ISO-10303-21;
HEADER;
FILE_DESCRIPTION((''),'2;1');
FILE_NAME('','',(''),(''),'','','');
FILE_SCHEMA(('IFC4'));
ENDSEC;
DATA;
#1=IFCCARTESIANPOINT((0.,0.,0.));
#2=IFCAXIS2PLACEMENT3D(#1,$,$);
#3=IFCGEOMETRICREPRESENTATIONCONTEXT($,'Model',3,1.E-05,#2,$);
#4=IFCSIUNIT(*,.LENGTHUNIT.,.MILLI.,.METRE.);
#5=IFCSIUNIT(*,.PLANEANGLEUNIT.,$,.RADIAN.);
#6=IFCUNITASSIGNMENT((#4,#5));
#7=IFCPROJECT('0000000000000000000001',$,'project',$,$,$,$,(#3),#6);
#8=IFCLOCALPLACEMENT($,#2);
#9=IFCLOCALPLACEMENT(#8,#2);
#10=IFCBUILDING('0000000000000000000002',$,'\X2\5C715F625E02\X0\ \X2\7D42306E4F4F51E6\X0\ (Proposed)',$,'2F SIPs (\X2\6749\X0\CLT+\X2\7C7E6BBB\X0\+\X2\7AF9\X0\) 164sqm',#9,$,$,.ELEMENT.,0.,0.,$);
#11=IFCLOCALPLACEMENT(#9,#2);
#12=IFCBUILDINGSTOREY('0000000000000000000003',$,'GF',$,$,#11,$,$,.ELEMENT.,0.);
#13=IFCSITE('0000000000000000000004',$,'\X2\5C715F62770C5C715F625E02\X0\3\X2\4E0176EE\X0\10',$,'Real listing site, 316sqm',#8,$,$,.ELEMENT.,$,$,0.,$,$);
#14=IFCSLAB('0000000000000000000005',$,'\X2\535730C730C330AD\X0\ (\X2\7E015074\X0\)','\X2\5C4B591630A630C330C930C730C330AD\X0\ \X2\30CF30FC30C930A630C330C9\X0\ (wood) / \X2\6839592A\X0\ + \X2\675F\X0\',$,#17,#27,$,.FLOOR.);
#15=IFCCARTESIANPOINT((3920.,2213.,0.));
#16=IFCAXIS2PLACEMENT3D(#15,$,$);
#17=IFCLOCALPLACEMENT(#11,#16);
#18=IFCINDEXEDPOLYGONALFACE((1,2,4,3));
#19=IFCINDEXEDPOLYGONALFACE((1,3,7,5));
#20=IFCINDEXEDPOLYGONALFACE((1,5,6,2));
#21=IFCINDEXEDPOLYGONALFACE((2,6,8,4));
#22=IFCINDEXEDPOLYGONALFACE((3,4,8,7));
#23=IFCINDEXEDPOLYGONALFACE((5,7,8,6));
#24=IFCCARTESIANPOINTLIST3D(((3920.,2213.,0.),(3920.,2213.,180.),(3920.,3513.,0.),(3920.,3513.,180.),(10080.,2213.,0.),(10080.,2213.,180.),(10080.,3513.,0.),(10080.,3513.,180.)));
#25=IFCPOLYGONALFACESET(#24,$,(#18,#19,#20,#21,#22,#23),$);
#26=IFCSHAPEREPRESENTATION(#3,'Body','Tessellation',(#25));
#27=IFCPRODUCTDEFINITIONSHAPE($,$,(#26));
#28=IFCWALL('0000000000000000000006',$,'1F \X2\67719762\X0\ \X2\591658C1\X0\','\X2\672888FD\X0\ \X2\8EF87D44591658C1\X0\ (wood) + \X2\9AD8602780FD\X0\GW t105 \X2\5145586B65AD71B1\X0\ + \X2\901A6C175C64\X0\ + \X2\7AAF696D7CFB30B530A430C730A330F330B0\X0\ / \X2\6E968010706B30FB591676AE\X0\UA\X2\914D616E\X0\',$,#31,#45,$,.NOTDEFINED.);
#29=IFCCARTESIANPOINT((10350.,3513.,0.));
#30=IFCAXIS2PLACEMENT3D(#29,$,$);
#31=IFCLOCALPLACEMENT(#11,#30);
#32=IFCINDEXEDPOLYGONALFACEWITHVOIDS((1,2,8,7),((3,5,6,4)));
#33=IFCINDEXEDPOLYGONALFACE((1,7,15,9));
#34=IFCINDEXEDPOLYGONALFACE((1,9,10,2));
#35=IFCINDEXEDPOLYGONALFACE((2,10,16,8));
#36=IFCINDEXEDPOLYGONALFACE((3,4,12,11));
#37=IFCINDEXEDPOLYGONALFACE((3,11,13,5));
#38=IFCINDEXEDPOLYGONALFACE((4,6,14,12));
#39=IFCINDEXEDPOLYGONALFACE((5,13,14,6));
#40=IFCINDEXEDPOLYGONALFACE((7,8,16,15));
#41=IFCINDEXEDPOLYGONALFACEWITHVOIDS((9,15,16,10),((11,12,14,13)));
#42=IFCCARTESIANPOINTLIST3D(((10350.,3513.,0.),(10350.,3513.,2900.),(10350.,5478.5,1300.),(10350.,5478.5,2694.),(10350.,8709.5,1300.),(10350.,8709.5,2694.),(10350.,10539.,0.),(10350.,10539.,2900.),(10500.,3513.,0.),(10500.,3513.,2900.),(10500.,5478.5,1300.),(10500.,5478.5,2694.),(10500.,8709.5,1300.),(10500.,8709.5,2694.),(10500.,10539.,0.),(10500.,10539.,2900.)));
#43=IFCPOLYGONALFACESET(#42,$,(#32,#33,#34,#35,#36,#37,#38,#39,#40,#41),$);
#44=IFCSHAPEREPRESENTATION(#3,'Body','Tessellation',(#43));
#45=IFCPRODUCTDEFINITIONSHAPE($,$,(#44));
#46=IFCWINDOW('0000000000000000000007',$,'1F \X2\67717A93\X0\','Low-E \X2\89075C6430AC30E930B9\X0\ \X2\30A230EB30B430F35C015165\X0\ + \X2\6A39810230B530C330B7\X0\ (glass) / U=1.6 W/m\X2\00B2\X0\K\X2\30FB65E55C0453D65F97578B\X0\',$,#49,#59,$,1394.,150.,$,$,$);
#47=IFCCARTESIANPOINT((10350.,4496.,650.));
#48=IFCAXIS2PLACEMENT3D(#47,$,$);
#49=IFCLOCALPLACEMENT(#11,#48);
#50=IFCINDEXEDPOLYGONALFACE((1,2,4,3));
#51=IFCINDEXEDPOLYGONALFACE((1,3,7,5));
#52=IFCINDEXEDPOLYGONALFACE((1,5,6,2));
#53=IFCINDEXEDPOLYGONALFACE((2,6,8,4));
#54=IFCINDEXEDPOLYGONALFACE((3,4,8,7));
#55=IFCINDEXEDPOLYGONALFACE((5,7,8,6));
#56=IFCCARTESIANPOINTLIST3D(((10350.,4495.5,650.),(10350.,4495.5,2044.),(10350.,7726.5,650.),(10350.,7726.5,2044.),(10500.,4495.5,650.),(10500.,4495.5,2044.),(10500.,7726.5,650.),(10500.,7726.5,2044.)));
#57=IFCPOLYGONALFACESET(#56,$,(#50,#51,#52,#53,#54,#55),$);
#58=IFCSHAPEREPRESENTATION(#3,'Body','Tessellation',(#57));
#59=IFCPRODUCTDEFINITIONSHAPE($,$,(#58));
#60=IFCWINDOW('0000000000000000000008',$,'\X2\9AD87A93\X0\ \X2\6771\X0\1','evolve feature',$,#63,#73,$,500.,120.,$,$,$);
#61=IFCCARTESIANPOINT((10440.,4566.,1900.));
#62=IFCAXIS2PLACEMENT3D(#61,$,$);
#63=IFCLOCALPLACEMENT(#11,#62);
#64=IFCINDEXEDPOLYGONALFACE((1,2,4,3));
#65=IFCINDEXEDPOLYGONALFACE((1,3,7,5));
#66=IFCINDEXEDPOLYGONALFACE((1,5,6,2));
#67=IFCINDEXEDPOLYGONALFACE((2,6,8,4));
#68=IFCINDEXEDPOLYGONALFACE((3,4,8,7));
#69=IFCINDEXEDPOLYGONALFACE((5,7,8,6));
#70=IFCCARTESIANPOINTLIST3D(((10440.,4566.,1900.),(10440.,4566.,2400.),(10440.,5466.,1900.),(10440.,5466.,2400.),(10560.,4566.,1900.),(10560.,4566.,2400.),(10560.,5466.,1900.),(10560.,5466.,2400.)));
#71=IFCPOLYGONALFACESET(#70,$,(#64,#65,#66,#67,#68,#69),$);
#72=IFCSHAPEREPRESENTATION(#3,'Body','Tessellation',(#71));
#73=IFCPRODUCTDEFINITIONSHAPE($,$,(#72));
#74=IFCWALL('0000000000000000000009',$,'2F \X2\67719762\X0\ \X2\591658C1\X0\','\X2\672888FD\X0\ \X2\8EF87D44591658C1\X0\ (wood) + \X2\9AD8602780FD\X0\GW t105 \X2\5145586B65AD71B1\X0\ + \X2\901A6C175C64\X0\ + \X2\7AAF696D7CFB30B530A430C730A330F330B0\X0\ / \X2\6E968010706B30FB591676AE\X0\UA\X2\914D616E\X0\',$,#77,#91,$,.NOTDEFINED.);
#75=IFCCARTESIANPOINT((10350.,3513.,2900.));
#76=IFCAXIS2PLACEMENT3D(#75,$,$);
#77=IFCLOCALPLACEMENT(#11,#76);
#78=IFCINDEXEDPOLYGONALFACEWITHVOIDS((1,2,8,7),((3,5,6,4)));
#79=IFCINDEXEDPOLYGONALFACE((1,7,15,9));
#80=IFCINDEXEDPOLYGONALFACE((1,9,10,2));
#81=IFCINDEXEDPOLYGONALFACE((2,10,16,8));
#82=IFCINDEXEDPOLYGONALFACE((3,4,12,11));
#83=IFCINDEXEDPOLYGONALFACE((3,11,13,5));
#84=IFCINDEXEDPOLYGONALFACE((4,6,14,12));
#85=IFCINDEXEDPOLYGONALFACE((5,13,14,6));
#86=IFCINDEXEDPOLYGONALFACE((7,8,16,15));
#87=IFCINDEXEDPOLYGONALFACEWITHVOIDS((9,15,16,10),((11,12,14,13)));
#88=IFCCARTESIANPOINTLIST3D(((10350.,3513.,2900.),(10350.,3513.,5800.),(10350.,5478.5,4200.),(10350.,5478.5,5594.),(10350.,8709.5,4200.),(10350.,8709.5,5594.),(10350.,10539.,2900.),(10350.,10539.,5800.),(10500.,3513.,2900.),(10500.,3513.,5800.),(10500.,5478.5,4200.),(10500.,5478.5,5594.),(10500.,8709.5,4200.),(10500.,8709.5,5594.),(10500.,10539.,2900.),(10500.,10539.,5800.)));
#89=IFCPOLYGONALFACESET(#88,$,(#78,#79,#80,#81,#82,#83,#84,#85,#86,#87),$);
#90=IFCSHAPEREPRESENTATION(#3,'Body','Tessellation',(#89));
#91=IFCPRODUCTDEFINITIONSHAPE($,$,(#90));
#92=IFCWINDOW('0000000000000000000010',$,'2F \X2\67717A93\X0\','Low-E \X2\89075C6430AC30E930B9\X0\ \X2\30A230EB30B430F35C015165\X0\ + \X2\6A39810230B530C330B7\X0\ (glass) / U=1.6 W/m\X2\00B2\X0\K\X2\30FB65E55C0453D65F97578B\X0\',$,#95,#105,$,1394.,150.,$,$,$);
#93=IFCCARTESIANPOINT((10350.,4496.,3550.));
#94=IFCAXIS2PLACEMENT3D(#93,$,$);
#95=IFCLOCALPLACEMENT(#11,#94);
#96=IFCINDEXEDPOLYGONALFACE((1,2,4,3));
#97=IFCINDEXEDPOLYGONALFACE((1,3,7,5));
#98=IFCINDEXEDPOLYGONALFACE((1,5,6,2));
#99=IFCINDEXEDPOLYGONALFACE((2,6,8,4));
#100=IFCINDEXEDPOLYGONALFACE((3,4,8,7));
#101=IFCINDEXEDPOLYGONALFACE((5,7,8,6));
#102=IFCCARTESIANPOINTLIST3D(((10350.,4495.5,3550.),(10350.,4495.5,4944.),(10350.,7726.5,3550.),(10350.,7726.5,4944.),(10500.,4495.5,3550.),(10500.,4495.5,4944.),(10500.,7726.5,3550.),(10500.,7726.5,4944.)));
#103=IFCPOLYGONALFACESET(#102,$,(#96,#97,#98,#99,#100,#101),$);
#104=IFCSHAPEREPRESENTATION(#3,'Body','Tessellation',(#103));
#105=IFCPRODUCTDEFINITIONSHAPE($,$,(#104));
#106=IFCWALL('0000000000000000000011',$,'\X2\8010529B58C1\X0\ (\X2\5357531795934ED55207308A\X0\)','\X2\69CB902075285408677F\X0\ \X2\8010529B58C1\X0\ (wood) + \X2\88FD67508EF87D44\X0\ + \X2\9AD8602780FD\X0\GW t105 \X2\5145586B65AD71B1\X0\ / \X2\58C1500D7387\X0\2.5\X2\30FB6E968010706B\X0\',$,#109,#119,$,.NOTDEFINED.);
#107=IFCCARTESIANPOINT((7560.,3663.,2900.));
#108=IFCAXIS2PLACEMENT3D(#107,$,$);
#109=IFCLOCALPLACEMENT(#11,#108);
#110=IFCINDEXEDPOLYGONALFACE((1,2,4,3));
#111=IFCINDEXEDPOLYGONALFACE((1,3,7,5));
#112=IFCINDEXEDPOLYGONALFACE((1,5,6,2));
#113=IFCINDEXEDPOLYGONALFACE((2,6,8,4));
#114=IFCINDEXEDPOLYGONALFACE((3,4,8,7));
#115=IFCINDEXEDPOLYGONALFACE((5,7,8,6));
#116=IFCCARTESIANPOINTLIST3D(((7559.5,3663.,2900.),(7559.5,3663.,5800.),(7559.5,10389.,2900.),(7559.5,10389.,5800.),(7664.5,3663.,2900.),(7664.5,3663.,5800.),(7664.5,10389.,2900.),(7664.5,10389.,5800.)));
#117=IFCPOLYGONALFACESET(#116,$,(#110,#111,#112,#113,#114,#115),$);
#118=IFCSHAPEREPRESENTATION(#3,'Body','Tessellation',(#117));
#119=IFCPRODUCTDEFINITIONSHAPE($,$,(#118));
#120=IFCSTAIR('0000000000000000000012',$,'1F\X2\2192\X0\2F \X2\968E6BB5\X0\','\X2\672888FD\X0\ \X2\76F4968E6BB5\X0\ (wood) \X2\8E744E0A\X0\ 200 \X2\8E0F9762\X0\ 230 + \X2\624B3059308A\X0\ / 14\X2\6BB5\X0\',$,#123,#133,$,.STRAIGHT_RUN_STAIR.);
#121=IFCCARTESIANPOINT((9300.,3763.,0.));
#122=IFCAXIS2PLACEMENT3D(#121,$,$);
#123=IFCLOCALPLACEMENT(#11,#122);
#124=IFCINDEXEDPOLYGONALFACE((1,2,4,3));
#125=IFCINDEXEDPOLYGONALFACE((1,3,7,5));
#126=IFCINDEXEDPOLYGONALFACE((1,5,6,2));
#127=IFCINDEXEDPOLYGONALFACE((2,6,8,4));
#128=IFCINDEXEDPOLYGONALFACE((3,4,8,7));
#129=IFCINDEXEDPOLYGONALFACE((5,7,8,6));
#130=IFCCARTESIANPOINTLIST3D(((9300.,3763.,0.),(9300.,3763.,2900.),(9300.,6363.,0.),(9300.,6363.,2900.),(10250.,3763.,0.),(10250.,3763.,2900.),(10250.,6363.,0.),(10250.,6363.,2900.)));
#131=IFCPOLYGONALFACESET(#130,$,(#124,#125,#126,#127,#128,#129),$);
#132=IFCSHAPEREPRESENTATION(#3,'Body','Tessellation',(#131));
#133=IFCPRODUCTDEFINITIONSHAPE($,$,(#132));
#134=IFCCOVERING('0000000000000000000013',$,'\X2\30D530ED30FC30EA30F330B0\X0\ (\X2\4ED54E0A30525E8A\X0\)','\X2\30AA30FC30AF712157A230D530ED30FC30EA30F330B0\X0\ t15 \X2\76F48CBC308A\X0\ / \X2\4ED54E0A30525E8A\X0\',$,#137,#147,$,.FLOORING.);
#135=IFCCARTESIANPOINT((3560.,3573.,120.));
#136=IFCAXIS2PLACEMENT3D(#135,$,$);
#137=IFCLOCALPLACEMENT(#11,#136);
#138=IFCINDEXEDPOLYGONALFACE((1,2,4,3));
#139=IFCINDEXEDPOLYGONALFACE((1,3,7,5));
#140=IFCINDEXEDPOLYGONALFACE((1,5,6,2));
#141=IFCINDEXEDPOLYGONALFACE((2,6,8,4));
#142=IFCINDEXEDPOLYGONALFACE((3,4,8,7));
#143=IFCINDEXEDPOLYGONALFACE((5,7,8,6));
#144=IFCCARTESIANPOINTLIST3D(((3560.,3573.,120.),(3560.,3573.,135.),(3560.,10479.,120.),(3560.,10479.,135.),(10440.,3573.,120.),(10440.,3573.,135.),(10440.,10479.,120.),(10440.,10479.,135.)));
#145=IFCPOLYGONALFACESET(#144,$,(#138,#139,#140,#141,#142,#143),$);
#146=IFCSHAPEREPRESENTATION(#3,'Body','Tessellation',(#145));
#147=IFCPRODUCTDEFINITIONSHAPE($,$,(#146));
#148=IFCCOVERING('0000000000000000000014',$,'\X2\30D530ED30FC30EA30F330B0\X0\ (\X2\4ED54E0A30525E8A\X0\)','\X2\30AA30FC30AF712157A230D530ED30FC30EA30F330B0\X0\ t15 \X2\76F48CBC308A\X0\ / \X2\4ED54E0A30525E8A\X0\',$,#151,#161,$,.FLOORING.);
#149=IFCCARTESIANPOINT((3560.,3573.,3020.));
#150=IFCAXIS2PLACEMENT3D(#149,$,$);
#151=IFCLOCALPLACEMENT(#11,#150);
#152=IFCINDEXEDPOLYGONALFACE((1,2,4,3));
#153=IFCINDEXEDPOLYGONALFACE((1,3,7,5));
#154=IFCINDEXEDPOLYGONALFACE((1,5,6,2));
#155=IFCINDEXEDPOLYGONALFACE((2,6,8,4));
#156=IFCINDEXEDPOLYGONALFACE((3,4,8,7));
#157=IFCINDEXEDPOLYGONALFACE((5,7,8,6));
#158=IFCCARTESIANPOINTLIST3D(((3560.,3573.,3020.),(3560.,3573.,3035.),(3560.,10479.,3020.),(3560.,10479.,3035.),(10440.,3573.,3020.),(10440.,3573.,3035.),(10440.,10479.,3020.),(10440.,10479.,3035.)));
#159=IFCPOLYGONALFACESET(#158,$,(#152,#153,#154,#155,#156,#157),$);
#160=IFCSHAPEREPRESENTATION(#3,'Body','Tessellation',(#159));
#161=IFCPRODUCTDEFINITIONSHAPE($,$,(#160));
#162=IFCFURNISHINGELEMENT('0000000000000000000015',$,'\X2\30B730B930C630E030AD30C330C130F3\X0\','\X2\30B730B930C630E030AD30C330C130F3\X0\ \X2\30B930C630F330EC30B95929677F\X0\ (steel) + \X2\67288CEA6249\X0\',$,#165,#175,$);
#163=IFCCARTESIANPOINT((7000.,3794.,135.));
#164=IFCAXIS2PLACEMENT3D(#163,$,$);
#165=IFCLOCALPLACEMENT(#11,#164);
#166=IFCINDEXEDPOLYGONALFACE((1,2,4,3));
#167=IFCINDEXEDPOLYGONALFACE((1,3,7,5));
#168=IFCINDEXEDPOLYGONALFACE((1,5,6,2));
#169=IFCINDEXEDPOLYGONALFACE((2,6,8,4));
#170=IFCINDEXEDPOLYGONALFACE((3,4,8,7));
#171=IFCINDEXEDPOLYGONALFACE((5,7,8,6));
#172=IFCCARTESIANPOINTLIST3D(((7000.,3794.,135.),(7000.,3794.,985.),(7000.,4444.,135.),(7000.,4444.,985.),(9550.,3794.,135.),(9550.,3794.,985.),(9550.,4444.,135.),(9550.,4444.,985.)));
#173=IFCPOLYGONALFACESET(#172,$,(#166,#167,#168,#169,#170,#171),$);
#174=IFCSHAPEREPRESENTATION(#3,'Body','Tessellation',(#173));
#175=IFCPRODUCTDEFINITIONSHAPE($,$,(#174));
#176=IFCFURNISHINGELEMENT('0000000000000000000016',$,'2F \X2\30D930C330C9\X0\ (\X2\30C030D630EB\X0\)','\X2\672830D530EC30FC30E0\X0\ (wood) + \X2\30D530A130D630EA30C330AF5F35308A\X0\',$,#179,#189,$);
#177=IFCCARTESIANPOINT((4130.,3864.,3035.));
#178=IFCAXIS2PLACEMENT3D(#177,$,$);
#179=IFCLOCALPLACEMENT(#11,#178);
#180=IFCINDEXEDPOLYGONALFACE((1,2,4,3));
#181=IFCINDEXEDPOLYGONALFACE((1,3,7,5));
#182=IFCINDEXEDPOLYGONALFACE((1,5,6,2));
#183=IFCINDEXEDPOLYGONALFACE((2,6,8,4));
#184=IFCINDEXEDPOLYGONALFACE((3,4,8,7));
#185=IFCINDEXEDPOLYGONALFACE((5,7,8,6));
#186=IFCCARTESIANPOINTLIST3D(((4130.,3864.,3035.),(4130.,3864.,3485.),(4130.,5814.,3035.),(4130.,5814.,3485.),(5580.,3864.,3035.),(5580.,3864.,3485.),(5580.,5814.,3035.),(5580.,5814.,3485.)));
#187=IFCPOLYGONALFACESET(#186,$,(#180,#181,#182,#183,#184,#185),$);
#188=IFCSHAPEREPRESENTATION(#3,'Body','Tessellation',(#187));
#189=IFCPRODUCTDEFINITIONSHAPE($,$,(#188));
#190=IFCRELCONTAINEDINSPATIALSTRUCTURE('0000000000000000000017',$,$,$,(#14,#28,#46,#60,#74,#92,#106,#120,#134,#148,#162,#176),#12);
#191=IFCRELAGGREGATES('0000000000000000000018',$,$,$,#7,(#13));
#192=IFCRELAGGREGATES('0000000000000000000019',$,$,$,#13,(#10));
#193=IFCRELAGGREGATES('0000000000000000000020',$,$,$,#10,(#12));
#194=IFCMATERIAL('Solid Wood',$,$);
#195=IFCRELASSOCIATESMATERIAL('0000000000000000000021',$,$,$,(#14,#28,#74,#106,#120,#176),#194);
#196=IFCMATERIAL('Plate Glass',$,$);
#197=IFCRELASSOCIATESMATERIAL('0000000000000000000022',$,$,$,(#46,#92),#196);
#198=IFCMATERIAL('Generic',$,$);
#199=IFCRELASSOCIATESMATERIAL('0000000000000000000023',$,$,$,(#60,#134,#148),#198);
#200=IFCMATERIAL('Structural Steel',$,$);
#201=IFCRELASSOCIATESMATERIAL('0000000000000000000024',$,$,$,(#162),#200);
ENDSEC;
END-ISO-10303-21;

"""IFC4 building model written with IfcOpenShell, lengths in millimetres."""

from ifc_helpers import new_model, si_unit, frame, frame_2d, origin, place, context, project, spatial, rectangle, extrude, material, element, fill, save


model = new_model("IFC4")

# Units and contexts
model_context = context("Model", 3, precision=1e-05, world=origin())
ifc_project = project(units=[si_unit("LENGTHUNIT", "METRE", prefix="MILLI"), si_unit("PLANEANGLEUNIT", "RADIAN")], contexts=[model_context])

# Site, building, storey
site_placement = place(None, origin())
site = spatial("IfcSite", under=ifc_project, at=site_placement, Name="山形県山形市3丁目10", ObjectType="Real listing site, 316sqm", CompositionType="ELEMENT", RefElevation=0.0)
building_placement = place(site_placement, origin())
building = spatial("IfcBuilding", under=site, at=building_placement, Name="山形市 終の住処 (Proposed)", ObjectType="2F SIPs (杉CLT+籾殻+竹) 164sqm", CompositionType="ELEMENT", ElevationOfRefHeight=0.0, ElevationOfTerrain=0.0)
storey_placement = place(building_placement, origin())
storey = spatial("IfcBuildingStorey", under=building, at=storey_placement, Name="GF", CompositionType="ELEMENT", Elevation=0.0)

# Slab
ifc_material_1 = material(Name="Solid Wood")
slab_placement = place(storey_placement, frame((3920.0, 2213.0, 0.0)))
element("IfcSlab", 1, at=slab_placement, inside=storey, material=ifc_material_1, Name="南デッキ (縁側)", Description="屋外ウッドデッキ ハードウッド (wood) / 根太 + 束", PredefinedType="FLOOR", context=model_context, shape_type="SweptSolid", body=[
    extrude(rectangle(XDim=6160.0, YDim=1300.0, at=frame_2d((3080.0, 650.0))), frame((3920.0, 2213.0, 0.0)), (0.0, 0.0, 1.0), 180.0),
])

# Wall, openings, windows
wall_1_placement = place(storey_placement, frame((10350.0, 3513.0, 0.0)))
wall_1 = element("IfcWall", 2, at=wall_1_placement, inside=storey, material=ifc_material_1, Name="1F 東面 外壁", Description="木製 軸組外壁 (wood) + 高性能GW t105 充填断熱 + 通気層 + 窯業系サイディング / 準耐火・外皮UA配慮", PredefinedType="NOTDEFINED", context=model_context, shape_type="SweptSolid", body=[
    extrude(rectangle(XDim=150.0, YDim=7026.0, at=frame_2d((75.0, 3513.0))), frame((10350.0, 3513.0, 0.0)), (0.0, 0.0, 1.0), 2900.0),
])
opening_1_placement = place(storey_placement, frame((10350.0, 4496.0, 650.0)))
opening_1 = element("IfcOpeningElement", 3, at=opening_1_placement, cuts=wall_1, PredefinedType="NOTDEFINED", context=model_context, shape_type="SweptSolid", body=[
    extrude(rectangle(XDim=150.0, YDim=3231.0, at=frame_2d((75.0, 1615.0))), frame((10350.0, 4496.0, 650.0)), (0.0, 0.0, 1.0), 1394.0),
])
opening_2_placement = place(storey_placement, frame((10440.0, 4566.0, 1900.0)))
opening_2 = element("IfcOpeningElement", 4, at=opening_2_placement, cuts=wall_1, PredefinedType="NOTDEFINED", context=model_context, shape_type="SweptSolid", body=[
    extrude(rectangle(XDim=120.0, YDim=900.0, at=frame_2d((60.0, 450.0))), frame((10440.0, 4566.0, 1900.0)), (0.0, 0.0, 1.0), 500.0),
])
ifc_material_2 = material(Name="Plate Glass")
window_1_placement = place(storey_placement, frame((10350.0, 4496.0, 650.0)))
window_1 = element("IfcWindow", 5, at=window_1_placement, inside=storey, material=ifc_material_2, Name="1F 東窓", Description="Low-E 複層ガラス アルゴン封入 + 樹脂サッシ (glass) / U=1.6 W/m²K・日射取得型", OverallHeight=1394.0, OverallWidth=150.0, context=model_context, shape_type="SweptSolid", body=[
    extrude(rectangle(XDim=150.0, YDim=3231.0, at=frame_2d((75.0, 1615.0))), frame((10350.0, 4496.0, 650.0)), (0.0, 0.0, 1.0), 1394.0),
])
fill(opening_1, window_1)
ifc_material_3 = material(Name="Generic")
window_2_placement = place(storey_placement, frame((10440.0, 4566.0, 1900.0)))
window_2 = element("IfcWindow", 6, at=window_2_placement, inside=storey, material=ifc_material_3, Name="高窓 東1", Description="evolve feature", OverallHeight=500.0, OverallWidth=120.0, context=model_context, shape_type="SweptSolid", body=[
    extrude(rectangle(XDim=120.0, YDim=900.0, at=frame_2d((60.0, 450.0))), frame((10440.0, 4566.0, 1900.0)), (0.0, 0.0, 1.0), 500.0),
])
fill(opening_2, window_2)

# Wall, opening, window
wall_2_placement = place(storey_placement, frame((10350.0, 3513.0, 2900.0)))
wall_2 = element("IfcWall", 7, at=wall_2_placement, inside=storey, material=ifc_material_1, Name="2F 東面 外壁", Description="木製 軸組外壁 (wood) + 高性能GW t105 充填断熱 + 通気層 + 窯業系サイディング / 準耐火・外皮UA配慮", PredefinedType="NOTDEFINED", context=model_context, shape_type="SweptSolid", body=[
    extrude(rectangle(XDim=150.0, YDim=7026.0, at=frame_2d((75.0, 3513.0))), frame((10350.0, 3513.0, 2900.0)), (0.0, 0.0, 1.0), 2900.0),
])
opening_3_placement = place(storey_placement, frame((10350.0, 4496.0, 3550.0)))
opening_3 = element("IfcOpeningElement", 8, at=opening_3_placement, cuts=wall_2, PredefinedType="NOTDEFINED", context=model_context, shape_type="SweptSolid", body=[
    extrude(rectangle(XDim=150.0, YDim=3231.0, at=frame_2d((75.0, 1615.0))), frame((10350.0, 4496.0, 3550.0)), (0.0, 0.0, 1.0), 1394.0),
])
window_3_placement = place(storey_placement, frame((10350.0, 4496.0, 3550.0)))
window_3 = element("IfcWindow", 9, at=window_3_placement, inside=storey, material=ifc_material_2, Name="2F 東窓", Description="Low-E 複層ガラス アルゴン封入 + 樹脂サッシ (glass) / U=1.6 W/m²K・日射取得型", OverallHeight=1394.0, OverallWidth=150.0, context=model_context, shape_type="SweptSolid", body=[
    extrude(rectangle(XDim=150.0, YDim=3231.0, at=frame_2d((75.0, 1615.0))), frame((10350.0, 4496.0, 3550.0)), (0.0, 0.0, 1.0), 1394.0),
])
fill(opening_3, window_3)

# Wall
wall_3_placement = place(storey_placement, frame((7560.0, 3663.0, 2900.0)))
element("IfcWall", 10, at=wall_3_placement, inside=storey, material=ifc_material_1, Name="耐力壁 (南北間仕切り)", Description="構造用合板 耐力壁 (wood) + 製材軸組 + 高性能GW t105 充填断熱 / 壁倍率2.5・準耐火", PredefinedType="NOTDEFINED", context=model_context, shape_type="SweptSolid", body=[
    extrude(rectangle(XDim=105.0, YDim=6726.0, at=frame_2d((52.0, 3363.0))), frame((7560.0, 3663.0, 2900.0)), (0.0, 0.0, 1.0), 2900.0),
])

# Stair
stair_placement = place(storey_placement, frame((9300.0, 3763.0, 0.0)))
element("IfcStair", 11, at=stair_placement, inside=storey, material=ifc_material_1, Name="1F→2F 階段", Description="木製 直階段 (wood) 蹴上 200 踏面 230 + 手すり / 14段", PredefinedType="STRAIGHT_RUN_STAIR", context=model_context, shape_type="SweptSolid", body=[
    extrude(rectangle(XDim=950.0, YDim=2600.0, at=frame_2d((475.0, 1300.0))), frame((9300.0, 3763.0, 0.0)), (0.0, 0.0, 1.0), 2900.0),
])

# Coverings
covering_1_placement = place(storey_placement, frame((3560.0, 3573.0, 120.0)))
element("IfcCovering", 12, at=covering_1_placement, inside=storey, material=ifc_material_3, Name="フローリング (仕上げ床)", Description="オーク無垢フローリング t15 直貼り / 仕上げ床", PredefinedType="FLOORING", context=model_context, shape_type="SweptSolid", body=[
    extrude(rectangle(XDim=6880.0, YDim=6906.0, at=frame_2d((3440.0, 3453.0))), frame((3560.0, 3573.0, 120.0)), (0.0, 0.0, 1.0), 15.0),
])
covering_2_placement = place(storey_placement, frame((3560.0, 3573.0, 3020.0)))
element("IfcCovering", 13, at=covering_2_placement, inside=storey, material=ifc_material_3, Name="フローリング (仕上げ床)", Description="オーク無垢フローリング t15 直貼り / 仕上げ床", PredefinedType="FLOORING", context=model_context, shape_type="SweptSolid", body=[
    extrude(rectangle(XDim=6880.0, YDim=6906.0, at=frame_2d((3440.0, 3453.0))), frame((3560.0, 3573.0, 3020.0)), (0.0, 0.0, 1.0), 15.0),
])

# Furnishing elements
ifc_material_4 = material(Name="Structural Steel")
furnishing_1_placement = place(storey_placement, frame((7000.0, 3794.0, 135.0)))
element("IfcFurnishingElement", 14, at=furnishing_1_placement, inside=storey, material=ifc_material_4, Name="システムキッチン", Description="システムキッチン ステンレス天板 (steel) + 木質扉", context=model_context, shape_type="SweptSolid", body=[
    extrude(rectangle(XDim=2550.0, YDim=650.0, at=frame_2d((1275.0, 325.0))), frame((7000.0, 3794.0, 135.0)), (0.0, 0.0, 1.0), 850.0),
])
furnishing_2_placement = place(storey_placement, frame((4130.0, 3864.0, 3035.0)))
element("IfcFurnishingElement", 15, at=furnishing_2_placement, inside=storey, material=ifc_material_1, Name="2F ベッド (ダブル)", Description="木フレーム (wood) + ファブリック張り", context=model_context, shape_type="SweptSolid", body=[
    extrude(rectangle(XDim=1450.0, YDim=1950.0, at=frame_2d((725.0, 975.0))), frame((4130.0, 3864.0, 3035.0)), (0.0, 0.0, 1.0), 450.0),
])

save(model, "model.ifc")
